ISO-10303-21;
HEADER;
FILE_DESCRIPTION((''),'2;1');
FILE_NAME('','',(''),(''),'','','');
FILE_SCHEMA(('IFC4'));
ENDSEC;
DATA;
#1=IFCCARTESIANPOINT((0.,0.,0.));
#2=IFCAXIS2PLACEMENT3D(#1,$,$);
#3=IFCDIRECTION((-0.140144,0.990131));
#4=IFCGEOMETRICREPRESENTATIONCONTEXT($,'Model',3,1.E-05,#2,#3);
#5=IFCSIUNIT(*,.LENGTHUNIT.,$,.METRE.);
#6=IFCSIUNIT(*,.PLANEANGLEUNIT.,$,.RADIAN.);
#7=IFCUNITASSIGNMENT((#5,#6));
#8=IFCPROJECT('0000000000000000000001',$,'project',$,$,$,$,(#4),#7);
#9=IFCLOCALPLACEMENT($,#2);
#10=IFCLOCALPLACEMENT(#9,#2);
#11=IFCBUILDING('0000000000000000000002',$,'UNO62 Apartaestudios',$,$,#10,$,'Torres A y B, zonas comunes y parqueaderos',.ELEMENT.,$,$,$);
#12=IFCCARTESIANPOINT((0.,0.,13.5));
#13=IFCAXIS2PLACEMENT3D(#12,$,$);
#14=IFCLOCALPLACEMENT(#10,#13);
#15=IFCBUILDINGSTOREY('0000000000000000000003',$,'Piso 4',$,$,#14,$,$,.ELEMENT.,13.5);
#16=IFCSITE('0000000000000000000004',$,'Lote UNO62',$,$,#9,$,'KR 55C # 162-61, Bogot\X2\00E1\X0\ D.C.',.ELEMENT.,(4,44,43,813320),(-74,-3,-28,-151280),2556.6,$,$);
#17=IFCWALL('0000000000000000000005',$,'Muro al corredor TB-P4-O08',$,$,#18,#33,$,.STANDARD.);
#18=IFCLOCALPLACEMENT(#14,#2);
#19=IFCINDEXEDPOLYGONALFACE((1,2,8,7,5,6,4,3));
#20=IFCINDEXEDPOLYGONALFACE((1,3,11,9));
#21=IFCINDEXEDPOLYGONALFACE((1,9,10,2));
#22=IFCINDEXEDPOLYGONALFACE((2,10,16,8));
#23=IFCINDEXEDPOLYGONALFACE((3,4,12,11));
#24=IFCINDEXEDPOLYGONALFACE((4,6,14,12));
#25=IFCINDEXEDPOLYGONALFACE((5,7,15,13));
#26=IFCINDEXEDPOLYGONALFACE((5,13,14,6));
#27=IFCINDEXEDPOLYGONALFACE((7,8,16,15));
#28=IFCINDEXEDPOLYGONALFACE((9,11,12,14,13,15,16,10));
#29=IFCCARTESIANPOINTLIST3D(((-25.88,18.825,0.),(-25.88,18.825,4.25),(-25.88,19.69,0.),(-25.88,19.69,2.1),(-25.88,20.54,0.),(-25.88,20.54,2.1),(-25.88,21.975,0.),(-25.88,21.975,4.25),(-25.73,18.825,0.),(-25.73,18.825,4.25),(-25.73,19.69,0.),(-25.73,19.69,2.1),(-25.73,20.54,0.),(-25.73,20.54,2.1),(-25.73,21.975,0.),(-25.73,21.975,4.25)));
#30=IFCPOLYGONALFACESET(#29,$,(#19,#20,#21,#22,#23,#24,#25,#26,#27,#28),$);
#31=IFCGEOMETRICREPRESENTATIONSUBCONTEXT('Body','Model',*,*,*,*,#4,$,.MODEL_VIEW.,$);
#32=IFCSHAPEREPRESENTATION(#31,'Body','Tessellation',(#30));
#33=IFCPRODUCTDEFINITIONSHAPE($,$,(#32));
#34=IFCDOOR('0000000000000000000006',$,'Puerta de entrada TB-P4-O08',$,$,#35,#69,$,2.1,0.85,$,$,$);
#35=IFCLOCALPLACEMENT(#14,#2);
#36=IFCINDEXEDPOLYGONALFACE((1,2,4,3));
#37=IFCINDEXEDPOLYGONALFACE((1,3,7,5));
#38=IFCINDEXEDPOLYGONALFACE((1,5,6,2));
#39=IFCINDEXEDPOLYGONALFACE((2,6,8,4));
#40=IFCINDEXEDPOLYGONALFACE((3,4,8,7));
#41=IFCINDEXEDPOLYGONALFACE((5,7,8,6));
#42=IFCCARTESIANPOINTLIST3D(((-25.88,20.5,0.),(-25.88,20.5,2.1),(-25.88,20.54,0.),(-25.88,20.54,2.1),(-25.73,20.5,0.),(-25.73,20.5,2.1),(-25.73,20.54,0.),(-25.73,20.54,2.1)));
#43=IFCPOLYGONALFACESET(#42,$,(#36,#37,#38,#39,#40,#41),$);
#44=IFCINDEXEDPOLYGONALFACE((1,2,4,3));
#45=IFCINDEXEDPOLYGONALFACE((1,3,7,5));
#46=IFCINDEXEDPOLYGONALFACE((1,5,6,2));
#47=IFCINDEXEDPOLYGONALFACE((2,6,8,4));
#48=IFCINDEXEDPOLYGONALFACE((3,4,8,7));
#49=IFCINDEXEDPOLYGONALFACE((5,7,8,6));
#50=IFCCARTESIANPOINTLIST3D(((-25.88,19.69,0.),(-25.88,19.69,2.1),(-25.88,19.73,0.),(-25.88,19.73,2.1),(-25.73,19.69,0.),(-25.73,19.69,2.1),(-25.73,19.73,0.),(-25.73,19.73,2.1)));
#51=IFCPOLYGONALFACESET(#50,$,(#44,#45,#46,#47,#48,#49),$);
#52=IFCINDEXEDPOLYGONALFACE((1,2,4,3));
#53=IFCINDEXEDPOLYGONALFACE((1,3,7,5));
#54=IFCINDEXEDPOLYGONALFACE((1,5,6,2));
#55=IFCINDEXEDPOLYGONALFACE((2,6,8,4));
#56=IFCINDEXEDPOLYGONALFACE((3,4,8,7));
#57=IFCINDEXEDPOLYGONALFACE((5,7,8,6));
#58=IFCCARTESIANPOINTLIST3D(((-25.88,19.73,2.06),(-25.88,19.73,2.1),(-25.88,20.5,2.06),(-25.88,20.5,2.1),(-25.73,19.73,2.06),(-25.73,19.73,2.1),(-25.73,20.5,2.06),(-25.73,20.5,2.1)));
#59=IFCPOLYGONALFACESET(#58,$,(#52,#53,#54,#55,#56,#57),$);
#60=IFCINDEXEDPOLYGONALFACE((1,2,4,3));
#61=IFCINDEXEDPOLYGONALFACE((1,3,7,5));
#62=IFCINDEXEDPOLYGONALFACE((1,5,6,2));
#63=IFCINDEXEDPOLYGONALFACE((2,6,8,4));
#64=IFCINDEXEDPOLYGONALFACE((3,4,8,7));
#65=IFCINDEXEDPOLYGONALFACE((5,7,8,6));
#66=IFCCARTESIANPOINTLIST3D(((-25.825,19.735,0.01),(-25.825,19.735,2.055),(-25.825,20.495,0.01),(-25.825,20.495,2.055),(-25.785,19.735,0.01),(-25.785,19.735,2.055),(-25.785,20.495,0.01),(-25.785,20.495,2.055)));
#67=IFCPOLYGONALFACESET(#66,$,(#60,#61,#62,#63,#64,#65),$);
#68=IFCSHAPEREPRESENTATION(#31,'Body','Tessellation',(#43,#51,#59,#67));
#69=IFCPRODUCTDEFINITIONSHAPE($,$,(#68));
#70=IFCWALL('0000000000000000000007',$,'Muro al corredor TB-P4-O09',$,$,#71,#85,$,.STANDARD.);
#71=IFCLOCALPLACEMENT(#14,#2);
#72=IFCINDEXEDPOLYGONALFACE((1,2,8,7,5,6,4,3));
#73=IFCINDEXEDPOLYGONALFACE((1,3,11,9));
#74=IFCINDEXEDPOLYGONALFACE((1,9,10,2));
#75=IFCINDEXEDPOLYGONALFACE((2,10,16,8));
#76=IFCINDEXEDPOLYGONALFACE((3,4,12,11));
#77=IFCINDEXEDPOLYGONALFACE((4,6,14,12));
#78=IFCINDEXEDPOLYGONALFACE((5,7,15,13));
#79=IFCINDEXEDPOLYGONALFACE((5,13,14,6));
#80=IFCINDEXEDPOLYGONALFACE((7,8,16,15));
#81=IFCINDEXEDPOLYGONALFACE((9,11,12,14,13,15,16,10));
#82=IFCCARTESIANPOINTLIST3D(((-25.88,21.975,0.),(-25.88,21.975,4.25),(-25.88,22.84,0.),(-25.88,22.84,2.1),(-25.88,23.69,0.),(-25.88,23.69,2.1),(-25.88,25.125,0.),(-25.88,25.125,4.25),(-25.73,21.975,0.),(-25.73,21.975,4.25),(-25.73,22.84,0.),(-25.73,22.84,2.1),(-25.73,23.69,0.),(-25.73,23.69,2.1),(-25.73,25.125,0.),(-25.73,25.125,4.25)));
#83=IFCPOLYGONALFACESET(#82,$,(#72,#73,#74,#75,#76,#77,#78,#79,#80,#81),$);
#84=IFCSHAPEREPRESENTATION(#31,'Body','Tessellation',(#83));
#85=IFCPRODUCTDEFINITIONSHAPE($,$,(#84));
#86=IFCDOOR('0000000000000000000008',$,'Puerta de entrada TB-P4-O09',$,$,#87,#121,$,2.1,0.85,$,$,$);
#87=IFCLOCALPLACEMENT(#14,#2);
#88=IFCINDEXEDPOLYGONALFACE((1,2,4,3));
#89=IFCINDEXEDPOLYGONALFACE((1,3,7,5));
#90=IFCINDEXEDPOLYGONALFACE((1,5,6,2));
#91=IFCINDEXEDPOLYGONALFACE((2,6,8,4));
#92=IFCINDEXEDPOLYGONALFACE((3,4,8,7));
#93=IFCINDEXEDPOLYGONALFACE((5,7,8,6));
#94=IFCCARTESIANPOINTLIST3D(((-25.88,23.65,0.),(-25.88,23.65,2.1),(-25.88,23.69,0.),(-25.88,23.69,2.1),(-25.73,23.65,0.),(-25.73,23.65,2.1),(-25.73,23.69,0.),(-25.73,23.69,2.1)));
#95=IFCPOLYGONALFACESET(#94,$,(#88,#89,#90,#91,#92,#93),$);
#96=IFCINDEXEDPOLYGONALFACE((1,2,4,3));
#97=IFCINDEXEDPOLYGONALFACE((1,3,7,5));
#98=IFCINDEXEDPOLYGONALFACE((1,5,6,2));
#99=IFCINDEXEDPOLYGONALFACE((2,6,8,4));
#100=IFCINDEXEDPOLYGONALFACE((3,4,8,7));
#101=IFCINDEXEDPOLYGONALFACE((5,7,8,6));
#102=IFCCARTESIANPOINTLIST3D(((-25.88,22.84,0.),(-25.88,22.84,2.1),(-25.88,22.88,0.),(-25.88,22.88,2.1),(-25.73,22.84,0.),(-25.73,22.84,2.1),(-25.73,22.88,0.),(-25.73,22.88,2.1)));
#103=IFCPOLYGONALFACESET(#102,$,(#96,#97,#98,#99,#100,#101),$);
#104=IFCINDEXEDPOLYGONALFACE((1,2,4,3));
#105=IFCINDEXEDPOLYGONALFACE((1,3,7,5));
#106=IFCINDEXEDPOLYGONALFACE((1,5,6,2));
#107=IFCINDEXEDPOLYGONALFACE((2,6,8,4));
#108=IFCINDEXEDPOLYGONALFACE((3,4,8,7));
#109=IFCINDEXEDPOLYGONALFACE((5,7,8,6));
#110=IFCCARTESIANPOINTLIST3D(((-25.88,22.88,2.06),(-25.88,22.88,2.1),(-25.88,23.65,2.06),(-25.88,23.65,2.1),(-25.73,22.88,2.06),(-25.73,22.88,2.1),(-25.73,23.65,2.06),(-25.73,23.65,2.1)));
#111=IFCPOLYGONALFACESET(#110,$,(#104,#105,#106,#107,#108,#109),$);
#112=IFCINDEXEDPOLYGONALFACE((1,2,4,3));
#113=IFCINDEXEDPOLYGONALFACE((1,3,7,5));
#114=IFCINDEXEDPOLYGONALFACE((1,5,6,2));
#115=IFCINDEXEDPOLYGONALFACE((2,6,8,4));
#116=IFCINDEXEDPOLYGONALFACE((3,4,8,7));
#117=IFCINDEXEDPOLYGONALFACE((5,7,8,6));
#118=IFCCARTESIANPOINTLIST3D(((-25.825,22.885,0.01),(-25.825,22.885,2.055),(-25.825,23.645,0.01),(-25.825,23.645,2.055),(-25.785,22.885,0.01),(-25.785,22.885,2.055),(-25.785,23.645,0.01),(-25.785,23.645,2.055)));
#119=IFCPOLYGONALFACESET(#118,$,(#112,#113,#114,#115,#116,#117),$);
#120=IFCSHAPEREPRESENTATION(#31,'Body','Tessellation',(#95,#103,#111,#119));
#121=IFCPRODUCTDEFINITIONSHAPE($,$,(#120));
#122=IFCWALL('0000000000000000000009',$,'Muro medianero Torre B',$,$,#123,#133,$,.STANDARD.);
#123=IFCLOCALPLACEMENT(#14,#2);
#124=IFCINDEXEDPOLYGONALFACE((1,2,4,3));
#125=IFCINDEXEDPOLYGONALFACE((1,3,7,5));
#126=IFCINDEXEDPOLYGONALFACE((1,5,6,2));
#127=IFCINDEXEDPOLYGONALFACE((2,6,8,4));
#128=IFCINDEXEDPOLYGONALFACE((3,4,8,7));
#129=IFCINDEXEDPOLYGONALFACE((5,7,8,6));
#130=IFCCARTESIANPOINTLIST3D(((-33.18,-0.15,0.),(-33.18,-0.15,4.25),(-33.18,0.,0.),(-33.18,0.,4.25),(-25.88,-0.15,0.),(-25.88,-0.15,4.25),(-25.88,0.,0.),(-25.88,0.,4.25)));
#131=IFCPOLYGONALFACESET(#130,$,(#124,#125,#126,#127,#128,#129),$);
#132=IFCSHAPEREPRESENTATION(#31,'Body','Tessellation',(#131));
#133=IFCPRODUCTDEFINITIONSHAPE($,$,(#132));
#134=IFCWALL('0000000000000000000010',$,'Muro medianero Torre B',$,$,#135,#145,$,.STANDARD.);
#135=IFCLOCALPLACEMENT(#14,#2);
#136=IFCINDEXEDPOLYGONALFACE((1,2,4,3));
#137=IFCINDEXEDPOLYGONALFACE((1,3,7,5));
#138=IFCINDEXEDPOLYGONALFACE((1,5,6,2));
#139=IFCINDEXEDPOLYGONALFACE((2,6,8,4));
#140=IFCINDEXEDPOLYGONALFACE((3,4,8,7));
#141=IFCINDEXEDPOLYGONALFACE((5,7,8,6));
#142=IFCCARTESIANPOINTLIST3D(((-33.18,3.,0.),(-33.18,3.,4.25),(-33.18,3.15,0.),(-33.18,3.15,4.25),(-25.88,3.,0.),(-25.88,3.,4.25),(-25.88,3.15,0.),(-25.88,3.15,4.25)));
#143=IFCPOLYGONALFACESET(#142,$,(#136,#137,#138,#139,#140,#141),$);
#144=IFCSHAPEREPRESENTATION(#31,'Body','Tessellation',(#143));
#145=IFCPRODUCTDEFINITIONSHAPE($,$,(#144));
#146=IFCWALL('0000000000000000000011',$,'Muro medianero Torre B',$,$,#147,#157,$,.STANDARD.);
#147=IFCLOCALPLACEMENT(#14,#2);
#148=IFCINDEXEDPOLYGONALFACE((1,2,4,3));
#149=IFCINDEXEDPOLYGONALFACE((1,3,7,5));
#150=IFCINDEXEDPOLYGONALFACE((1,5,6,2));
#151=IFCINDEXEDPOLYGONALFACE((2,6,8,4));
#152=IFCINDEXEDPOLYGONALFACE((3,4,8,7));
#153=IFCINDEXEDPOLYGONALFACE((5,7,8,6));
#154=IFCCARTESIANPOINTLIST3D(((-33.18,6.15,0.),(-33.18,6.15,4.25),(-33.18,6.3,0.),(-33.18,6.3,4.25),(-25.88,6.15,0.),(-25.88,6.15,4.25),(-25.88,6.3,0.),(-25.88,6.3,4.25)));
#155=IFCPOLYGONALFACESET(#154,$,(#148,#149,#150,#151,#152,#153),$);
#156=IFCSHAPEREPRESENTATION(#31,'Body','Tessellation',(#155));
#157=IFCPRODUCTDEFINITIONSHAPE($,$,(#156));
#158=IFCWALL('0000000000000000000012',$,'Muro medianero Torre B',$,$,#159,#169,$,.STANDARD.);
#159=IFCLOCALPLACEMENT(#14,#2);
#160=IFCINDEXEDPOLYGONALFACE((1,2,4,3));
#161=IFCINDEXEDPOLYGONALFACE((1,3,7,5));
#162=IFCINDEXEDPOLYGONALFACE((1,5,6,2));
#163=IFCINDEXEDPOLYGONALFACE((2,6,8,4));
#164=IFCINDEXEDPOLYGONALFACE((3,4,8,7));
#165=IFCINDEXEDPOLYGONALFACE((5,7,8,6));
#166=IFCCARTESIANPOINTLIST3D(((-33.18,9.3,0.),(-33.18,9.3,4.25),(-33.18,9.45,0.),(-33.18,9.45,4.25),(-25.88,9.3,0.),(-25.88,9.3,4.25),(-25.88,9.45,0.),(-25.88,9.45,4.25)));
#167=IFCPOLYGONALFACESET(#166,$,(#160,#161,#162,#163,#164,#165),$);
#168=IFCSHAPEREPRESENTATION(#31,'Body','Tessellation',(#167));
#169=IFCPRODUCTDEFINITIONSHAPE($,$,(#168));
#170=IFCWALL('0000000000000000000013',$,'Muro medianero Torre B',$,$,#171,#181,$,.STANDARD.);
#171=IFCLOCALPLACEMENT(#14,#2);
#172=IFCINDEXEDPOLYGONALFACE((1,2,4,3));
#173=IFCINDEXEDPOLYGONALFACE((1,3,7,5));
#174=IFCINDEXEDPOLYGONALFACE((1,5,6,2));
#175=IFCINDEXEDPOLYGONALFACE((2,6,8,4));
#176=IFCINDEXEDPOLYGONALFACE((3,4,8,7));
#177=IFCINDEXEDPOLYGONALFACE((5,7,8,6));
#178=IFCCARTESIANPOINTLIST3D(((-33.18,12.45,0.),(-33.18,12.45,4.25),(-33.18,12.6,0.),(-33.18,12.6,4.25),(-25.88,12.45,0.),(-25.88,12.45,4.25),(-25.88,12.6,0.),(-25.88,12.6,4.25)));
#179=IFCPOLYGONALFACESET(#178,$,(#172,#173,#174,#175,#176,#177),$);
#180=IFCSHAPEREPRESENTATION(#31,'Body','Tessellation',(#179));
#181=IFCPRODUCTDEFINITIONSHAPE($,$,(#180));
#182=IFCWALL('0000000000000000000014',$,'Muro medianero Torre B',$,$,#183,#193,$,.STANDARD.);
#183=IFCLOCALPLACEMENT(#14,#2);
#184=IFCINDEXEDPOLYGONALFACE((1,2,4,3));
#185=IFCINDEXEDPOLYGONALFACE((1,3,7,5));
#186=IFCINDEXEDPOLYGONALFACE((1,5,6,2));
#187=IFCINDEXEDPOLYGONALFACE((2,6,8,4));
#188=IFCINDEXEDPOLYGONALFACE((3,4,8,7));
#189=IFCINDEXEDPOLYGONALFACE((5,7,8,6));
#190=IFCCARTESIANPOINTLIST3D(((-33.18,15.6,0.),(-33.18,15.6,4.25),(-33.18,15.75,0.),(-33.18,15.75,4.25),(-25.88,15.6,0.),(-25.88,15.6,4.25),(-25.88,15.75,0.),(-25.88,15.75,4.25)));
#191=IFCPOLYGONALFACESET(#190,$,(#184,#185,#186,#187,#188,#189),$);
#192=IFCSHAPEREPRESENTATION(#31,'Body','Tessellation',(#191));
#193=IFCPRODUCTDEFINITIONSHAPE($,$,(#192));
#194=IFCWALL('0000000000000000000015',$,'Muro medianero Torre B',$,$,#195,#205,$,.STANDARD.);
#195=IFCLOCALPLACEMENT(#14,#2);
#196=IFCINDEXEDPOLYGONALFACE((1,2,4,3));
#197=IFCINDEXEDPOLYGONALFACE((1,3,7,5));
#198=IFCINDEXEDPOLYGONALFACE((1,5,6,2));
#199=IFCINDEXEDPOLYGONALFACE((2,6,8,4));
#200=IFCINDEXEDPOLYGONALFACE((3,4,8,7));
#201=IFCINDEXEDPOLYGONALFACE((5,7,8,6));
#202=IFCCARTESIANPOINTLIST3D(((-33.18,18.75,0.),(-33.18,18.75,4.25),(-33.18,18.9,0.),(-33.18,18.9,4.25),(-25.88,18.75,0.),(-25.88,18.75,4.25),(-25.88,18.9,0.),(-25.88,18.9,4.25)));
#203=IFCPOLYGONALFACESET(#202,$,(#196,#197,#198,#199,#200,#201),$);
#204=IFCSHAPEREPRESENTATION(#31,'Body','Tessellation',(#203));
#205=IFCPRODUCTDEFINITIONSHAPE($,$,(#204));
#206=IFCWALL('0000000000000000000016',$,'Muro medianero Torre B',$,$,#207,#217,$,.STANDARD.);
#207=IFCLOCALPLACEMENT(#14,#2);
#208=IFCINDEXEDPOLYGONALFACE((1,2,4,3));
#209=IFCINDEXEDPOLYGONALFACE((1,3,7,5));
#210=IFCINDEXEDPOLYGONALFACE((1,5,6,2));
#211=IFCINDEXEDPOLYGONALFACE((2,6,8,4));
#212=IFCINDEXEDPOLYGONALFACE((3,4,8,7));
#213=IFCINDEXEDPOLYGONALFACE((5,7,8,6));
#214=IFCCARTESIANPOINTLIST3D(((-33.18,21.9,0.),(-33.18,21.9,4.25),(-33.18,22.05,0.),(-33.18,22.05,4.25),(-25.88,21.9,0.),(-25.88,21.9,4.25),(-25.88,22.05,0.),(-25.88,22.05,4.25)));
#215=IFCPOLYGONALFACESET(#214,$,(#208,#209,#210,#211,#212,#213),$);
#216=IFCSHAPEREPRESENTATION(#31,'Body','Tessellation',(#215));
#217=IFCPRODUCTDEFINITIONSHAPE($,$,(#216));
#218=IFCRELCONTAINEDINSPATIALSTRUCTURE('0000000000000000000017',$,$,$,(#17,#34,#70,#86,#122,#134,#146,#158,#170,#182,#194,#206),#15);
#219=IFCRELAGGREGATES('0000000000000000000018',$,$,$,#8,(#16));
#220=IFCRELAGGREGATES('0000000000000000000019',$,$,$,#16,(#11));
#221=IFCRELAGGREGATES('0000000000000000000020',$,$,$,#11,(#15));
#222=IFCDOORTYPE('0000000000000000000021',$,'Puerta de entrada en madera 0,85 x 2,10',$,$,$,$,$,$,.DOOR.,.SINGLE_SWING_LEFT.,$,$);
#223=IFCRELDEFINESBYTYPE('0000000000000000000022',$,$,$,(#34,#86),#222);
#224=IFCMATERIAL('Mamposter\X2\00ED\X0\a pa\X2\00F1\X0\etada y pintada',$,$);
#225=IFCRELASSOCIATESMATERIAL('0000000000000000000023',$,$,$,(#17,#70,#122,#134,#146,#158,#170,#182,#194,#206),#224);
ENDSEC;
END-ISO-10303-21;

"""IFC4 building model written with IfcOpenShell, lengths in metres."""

from ifc_helpers import new_model, si_unit, direction, frame, frame_2d, origin, place, context, subcontext, project, spatial, rectangle, extrude, source, transform, mapped, material, type_object, type_shapes, element, fill, save


model = new_model("IFC4")

# Units and contexts
model_context = context("Model", 3, precision=1e-05, world=origin(), true_north=direction((-0.140144, 0.990131)))
body_context = subcontext(model_context, "Body", "Model", "MODEL_VIEW")
ifc_project = project(units=[si_unit("LENGTHUNIT", "METRE"), si_unit("PLANEANGLEUNIT", "RADIAN")], contexts=[model_context])

# Site, building, storey
site_placement = place(None, origin())
site = spatial("IfcSite", under=ifc_project, at=site_placement, Name="Lote UNO62", LongName="KR 55C # 162-61, Bogotá D.C.", CompositionType="ELEMENT", RefLatitude=(4, 44, 43, 813320), RefLongitude=(-74, -3, -28, -151280), RefElevation=2556.6)
building_placement = place(site_placement, origin())
building = spatial("IfcBuilding", under=site, at=building_placement, Name="UNO62 Apartaestudios", LongName="Torres A y B, zonas comunes y parqueaderos", CompositionType="ELEMENT")
storey_placement = place(building_placement, frame((0.0, 0.0, 13.5)))
storey = spatial("IfcBuildingStorey", under=building, at=storey_placement, Name="Piso 4", CompositionType="ELEMENT", Elevation=13.5)

# Walls, openings, doors
ifc_material_1 = material(Name="Mampostería pañetada y pintada")
door_type_1 = type_object("IfcDoorType", Name="Puerta de entrada en madera 0,85 x 2,10", OperationType="SINGLE_SWING_LEFT", PredefinedType="DOOR")
shared_shape_1 = source(origin(), body_context, "Body", "SweptSolid", [
    extrude(rectangle(XDim=0.15, YDim=0.04, at=frame_2d((-0.075, 1.38))), origin(), (0.0, 0.0, 1.0), 2.1),
    extrude(rectangle(XDim=0.15, YDim=0.04, at=frame_2d((-0.075, 2.19))), origin(), (0.0, 0.0, 1.0), 2.1),
    extrude(rectangle(XDim=0.15, YDim=0.77, at=frame_2d((-0.075, 1.785))), frame((0.0, 0.0, 2.06)), (0.0, 0.0, 1.0), 0.04),
    extrude(rectangle(XDim=0.04, YDim=0.76, at=frame_2d((-0.075, 1.785))), frame((0.0, 0.0, 0.01)), (0.0, 0.0, 1.0), 2.045),
])
type_shapes(door_type_1, [shared_shape_1])
wall_1_placement = place(storey_placement, origin())
wall_1 = element("IfcWall", 1, at=wall_1_placement, inside=storey, material=ifc_material_1, Name="Muro al corredor TB-P4-O08", PredefinedType="STANDARD", context=body_context, shape_type="SweptSolid", body=[
    extrude(rectangle(XDim=0.15, YDim=3.15, at=frame_2d((-25.805, 20.4))), origin(), (0.0, 0.0, 1.0), 4.25),
])
opening_1_placement = place(wall_1_placement, origin())
opening_1 = element("IfcOpeningElement", 2, at=opening_1_placement, cuts=wall_1, PredefinedType="OPENING", context=body_context, shape_type="SweptSolid", body=[
    extrude(rectangle(XDim=0.25, YDim=0.85, at=frame_2d((-25.805, 20.115))), origin(), (0.0, 0.0, 1.0), 2.1),
])
placement_1 = place(storey_placement, frame((-25.88, 21.9, 0.0), z_axis=(0.0, 0.0, 1.0), x_axis=(-1.0, 0.0, 0.0)))
door_1_placement = place(placement_1, origin())
door_1 = element("IfcDoor", 3, at=door_1_placement, inside=storey, type_object=door_type_1, Name="Puerta de entrada TB-P4-O08", OverallHeight=2.1, OverallWidth=0.85, context=body_context, shape_type="MappedRepresentation", body=[
    mapped(shared_shape_1, transform((0.0, 0.0, 0.0))),
])
fill(opening_1, door_1)
wall_2_placement = place(storey_placement, origin())
wall_2 = element("IfcWall", 4, at=wall_2_placement, inside=storey, material=ifc_material_1, Name="Muro al corredor TB-P4-O09", PredefinedType="STANDARD", context=body_context, shape_type="SweptSolid", body=[
    extrude(rectangle(XDim=0.15, YDim=3.15, at=frame_2d((-25.805, 23.55))), origin(), (0.0, 0.0, 1.0), 4.25),
])
opening_2_placement = place(wall_2_placement, origin())
opening_2 = element("IfcOpeningElement", 5, at=opening_2_placement, cuts=wall_2, PredefinedType="OPENING", context=body_context, shape_type="SweptSolid", body=[
    extrude(rectangle(XDim=0.25, YDim=0.85, at=frame_2d((-25.805, 23.265))), origin(), (0.0, 0.0, 1.0), 2.1),
])
placement_2 = place(storey_placement, frame((-25.88, 25.05, 0.0), z_axis=(0.0, 0.0, 1.0), x_axis=(-1.0, 0.0, 0.0)))
door_2_placement = place(placement_2, origin())
door_2 = element("IfcDoor", 6, at=door_2_placement, inside=storey, type_object=door_type_1, Name="Puerta de entrada TB-P4-O09", OverallHeight=2.1, OverallWidth=0.85, context=body_context, shape_type="MappedRepresentation", body=[
    mapped(shared_shape_1, transform((0.0, 0.0, 0.0))),
])
fill(opening_2, door_2)

# Walls
wall_3_placement = place(storey_placement, origin())
element("IfcWall", 7, at=wall_3_placement, inside=storey, material=ifc_material_1, Name="Muro medianero Torre B", PredefinedType="STANDARD", context=body_context, shape_type="SweptSolid", body=[
    extrude(rectangle(XDim=7.3, YDim=0.15, at=frame_2d((-29.53, -0.075))), origin(), (0.0, 0.0, 1.0), 4.25),
])
wall_4_placement = place(storey_placement, origin())
element("IfcWall", 8, at=wall_4_placement, inside=storey, material=ifc_material_1, Name="Muro medianero Torre B", PredefinedType="STANDARD", context=body_context, shape_type="SweptSolid", body=[
    extrude(rectangle(XDim=7.3, YDim=0.15, at=frame_2d((-29.53, 3.075))), origin(), (0.0, 0.0, 1.0), 4.25),
])
wall_5_placement = place(storey_placement, origin())
element("IfcWall", 9, at=wall_5_placement, inside=storey, material=ifc_material_1, Name="Muro medianero Torre B", PredefinedType="STANDARD", context=body_context, shape_type="SweptSolid", body=[
    extrude(rectangle(XDim=7.3, YDim=0.15, at=frame_2d((-29.53, 6.225))), origin(), (0.0, 0.0, 1.0), 4.25),
])
wall_6_placement = place(storey_placement, origin())
element("IfcWall", 10, at=wall_6_placement, inside=storey, material=ifc_material_1, Name="Muro medianero Torre B", PredefinedType="STANDARD", context=body_context, shape_type="SweptSolid", body=[
    extrude(rectangle(XDim=7.3, YDim=0.15, at=frame_2d((-29.53, 9.375))), origin(), (0.0, 0.0, 1.0), 4.25),
])
wall_7_placement = place(storey_placement, origin())
element("IfcWall", 11, at=wall_7_placement, inside=storey, material=ifc_material_1, Name="Muro medianero Torre B", PredefinedType="STANDARD", context=body_context, shape_type="SweptSolid", body=[
    extrude(rectangle(XDim=7.3, YDim=0.15, at=frame_2d((-29.53, 12.525))), origin(), (0.0, 0.0, 1.0), 4.25),
])
wall_8_placement = place(storey_placement, origin())
element("IfcWall", 12, at=wall_8_placement, inside=storey, material=ifc_material_1, Name="Muro medianero Torre B", PredefinedType="STANDARD", context=body_context, shape_type="SweptSolid", body=[
    extrude(rectangle(XDim=7.3, YDim=0.15, at=frame_2d((-29.53, 15.675))), origin(), (0.0, 0.0, 1.0), 4.25),
])
wall_9_placement = place(storey_placement, origin())
element("IfcWall", 13, at=wall_9_placement, inside=storey, material=ifc_material_1, Name="Muro medianero Torre B", PredefinedType="STANDARD", context=body_context, shape_type="SweptSolid", body=[
    extrude(rectangle(XDim=7.3, YDim=0.15, at=frame_2d((-29.53, 18.825))), origin(), (0.0, 0.0, 1.0), 4.25),
])
wall_10_placement = place(storey_placement, origin())
element("IfcWall", 14, at=wall_10_placement, inside=storey, material=ifc_material_1, Name="Muro medianero Torre B", PredefinedType="STANDARD", context=body_context, shape_type="SweptSolid", body=[
    extrude(rectangle(XDim=7.3, YDim=0.15, at=frame_2d((-29.53, 21.975))), origin(), (0.0, 0.0, 1.0), 4.25),
])

save(model, "model.ifc")
